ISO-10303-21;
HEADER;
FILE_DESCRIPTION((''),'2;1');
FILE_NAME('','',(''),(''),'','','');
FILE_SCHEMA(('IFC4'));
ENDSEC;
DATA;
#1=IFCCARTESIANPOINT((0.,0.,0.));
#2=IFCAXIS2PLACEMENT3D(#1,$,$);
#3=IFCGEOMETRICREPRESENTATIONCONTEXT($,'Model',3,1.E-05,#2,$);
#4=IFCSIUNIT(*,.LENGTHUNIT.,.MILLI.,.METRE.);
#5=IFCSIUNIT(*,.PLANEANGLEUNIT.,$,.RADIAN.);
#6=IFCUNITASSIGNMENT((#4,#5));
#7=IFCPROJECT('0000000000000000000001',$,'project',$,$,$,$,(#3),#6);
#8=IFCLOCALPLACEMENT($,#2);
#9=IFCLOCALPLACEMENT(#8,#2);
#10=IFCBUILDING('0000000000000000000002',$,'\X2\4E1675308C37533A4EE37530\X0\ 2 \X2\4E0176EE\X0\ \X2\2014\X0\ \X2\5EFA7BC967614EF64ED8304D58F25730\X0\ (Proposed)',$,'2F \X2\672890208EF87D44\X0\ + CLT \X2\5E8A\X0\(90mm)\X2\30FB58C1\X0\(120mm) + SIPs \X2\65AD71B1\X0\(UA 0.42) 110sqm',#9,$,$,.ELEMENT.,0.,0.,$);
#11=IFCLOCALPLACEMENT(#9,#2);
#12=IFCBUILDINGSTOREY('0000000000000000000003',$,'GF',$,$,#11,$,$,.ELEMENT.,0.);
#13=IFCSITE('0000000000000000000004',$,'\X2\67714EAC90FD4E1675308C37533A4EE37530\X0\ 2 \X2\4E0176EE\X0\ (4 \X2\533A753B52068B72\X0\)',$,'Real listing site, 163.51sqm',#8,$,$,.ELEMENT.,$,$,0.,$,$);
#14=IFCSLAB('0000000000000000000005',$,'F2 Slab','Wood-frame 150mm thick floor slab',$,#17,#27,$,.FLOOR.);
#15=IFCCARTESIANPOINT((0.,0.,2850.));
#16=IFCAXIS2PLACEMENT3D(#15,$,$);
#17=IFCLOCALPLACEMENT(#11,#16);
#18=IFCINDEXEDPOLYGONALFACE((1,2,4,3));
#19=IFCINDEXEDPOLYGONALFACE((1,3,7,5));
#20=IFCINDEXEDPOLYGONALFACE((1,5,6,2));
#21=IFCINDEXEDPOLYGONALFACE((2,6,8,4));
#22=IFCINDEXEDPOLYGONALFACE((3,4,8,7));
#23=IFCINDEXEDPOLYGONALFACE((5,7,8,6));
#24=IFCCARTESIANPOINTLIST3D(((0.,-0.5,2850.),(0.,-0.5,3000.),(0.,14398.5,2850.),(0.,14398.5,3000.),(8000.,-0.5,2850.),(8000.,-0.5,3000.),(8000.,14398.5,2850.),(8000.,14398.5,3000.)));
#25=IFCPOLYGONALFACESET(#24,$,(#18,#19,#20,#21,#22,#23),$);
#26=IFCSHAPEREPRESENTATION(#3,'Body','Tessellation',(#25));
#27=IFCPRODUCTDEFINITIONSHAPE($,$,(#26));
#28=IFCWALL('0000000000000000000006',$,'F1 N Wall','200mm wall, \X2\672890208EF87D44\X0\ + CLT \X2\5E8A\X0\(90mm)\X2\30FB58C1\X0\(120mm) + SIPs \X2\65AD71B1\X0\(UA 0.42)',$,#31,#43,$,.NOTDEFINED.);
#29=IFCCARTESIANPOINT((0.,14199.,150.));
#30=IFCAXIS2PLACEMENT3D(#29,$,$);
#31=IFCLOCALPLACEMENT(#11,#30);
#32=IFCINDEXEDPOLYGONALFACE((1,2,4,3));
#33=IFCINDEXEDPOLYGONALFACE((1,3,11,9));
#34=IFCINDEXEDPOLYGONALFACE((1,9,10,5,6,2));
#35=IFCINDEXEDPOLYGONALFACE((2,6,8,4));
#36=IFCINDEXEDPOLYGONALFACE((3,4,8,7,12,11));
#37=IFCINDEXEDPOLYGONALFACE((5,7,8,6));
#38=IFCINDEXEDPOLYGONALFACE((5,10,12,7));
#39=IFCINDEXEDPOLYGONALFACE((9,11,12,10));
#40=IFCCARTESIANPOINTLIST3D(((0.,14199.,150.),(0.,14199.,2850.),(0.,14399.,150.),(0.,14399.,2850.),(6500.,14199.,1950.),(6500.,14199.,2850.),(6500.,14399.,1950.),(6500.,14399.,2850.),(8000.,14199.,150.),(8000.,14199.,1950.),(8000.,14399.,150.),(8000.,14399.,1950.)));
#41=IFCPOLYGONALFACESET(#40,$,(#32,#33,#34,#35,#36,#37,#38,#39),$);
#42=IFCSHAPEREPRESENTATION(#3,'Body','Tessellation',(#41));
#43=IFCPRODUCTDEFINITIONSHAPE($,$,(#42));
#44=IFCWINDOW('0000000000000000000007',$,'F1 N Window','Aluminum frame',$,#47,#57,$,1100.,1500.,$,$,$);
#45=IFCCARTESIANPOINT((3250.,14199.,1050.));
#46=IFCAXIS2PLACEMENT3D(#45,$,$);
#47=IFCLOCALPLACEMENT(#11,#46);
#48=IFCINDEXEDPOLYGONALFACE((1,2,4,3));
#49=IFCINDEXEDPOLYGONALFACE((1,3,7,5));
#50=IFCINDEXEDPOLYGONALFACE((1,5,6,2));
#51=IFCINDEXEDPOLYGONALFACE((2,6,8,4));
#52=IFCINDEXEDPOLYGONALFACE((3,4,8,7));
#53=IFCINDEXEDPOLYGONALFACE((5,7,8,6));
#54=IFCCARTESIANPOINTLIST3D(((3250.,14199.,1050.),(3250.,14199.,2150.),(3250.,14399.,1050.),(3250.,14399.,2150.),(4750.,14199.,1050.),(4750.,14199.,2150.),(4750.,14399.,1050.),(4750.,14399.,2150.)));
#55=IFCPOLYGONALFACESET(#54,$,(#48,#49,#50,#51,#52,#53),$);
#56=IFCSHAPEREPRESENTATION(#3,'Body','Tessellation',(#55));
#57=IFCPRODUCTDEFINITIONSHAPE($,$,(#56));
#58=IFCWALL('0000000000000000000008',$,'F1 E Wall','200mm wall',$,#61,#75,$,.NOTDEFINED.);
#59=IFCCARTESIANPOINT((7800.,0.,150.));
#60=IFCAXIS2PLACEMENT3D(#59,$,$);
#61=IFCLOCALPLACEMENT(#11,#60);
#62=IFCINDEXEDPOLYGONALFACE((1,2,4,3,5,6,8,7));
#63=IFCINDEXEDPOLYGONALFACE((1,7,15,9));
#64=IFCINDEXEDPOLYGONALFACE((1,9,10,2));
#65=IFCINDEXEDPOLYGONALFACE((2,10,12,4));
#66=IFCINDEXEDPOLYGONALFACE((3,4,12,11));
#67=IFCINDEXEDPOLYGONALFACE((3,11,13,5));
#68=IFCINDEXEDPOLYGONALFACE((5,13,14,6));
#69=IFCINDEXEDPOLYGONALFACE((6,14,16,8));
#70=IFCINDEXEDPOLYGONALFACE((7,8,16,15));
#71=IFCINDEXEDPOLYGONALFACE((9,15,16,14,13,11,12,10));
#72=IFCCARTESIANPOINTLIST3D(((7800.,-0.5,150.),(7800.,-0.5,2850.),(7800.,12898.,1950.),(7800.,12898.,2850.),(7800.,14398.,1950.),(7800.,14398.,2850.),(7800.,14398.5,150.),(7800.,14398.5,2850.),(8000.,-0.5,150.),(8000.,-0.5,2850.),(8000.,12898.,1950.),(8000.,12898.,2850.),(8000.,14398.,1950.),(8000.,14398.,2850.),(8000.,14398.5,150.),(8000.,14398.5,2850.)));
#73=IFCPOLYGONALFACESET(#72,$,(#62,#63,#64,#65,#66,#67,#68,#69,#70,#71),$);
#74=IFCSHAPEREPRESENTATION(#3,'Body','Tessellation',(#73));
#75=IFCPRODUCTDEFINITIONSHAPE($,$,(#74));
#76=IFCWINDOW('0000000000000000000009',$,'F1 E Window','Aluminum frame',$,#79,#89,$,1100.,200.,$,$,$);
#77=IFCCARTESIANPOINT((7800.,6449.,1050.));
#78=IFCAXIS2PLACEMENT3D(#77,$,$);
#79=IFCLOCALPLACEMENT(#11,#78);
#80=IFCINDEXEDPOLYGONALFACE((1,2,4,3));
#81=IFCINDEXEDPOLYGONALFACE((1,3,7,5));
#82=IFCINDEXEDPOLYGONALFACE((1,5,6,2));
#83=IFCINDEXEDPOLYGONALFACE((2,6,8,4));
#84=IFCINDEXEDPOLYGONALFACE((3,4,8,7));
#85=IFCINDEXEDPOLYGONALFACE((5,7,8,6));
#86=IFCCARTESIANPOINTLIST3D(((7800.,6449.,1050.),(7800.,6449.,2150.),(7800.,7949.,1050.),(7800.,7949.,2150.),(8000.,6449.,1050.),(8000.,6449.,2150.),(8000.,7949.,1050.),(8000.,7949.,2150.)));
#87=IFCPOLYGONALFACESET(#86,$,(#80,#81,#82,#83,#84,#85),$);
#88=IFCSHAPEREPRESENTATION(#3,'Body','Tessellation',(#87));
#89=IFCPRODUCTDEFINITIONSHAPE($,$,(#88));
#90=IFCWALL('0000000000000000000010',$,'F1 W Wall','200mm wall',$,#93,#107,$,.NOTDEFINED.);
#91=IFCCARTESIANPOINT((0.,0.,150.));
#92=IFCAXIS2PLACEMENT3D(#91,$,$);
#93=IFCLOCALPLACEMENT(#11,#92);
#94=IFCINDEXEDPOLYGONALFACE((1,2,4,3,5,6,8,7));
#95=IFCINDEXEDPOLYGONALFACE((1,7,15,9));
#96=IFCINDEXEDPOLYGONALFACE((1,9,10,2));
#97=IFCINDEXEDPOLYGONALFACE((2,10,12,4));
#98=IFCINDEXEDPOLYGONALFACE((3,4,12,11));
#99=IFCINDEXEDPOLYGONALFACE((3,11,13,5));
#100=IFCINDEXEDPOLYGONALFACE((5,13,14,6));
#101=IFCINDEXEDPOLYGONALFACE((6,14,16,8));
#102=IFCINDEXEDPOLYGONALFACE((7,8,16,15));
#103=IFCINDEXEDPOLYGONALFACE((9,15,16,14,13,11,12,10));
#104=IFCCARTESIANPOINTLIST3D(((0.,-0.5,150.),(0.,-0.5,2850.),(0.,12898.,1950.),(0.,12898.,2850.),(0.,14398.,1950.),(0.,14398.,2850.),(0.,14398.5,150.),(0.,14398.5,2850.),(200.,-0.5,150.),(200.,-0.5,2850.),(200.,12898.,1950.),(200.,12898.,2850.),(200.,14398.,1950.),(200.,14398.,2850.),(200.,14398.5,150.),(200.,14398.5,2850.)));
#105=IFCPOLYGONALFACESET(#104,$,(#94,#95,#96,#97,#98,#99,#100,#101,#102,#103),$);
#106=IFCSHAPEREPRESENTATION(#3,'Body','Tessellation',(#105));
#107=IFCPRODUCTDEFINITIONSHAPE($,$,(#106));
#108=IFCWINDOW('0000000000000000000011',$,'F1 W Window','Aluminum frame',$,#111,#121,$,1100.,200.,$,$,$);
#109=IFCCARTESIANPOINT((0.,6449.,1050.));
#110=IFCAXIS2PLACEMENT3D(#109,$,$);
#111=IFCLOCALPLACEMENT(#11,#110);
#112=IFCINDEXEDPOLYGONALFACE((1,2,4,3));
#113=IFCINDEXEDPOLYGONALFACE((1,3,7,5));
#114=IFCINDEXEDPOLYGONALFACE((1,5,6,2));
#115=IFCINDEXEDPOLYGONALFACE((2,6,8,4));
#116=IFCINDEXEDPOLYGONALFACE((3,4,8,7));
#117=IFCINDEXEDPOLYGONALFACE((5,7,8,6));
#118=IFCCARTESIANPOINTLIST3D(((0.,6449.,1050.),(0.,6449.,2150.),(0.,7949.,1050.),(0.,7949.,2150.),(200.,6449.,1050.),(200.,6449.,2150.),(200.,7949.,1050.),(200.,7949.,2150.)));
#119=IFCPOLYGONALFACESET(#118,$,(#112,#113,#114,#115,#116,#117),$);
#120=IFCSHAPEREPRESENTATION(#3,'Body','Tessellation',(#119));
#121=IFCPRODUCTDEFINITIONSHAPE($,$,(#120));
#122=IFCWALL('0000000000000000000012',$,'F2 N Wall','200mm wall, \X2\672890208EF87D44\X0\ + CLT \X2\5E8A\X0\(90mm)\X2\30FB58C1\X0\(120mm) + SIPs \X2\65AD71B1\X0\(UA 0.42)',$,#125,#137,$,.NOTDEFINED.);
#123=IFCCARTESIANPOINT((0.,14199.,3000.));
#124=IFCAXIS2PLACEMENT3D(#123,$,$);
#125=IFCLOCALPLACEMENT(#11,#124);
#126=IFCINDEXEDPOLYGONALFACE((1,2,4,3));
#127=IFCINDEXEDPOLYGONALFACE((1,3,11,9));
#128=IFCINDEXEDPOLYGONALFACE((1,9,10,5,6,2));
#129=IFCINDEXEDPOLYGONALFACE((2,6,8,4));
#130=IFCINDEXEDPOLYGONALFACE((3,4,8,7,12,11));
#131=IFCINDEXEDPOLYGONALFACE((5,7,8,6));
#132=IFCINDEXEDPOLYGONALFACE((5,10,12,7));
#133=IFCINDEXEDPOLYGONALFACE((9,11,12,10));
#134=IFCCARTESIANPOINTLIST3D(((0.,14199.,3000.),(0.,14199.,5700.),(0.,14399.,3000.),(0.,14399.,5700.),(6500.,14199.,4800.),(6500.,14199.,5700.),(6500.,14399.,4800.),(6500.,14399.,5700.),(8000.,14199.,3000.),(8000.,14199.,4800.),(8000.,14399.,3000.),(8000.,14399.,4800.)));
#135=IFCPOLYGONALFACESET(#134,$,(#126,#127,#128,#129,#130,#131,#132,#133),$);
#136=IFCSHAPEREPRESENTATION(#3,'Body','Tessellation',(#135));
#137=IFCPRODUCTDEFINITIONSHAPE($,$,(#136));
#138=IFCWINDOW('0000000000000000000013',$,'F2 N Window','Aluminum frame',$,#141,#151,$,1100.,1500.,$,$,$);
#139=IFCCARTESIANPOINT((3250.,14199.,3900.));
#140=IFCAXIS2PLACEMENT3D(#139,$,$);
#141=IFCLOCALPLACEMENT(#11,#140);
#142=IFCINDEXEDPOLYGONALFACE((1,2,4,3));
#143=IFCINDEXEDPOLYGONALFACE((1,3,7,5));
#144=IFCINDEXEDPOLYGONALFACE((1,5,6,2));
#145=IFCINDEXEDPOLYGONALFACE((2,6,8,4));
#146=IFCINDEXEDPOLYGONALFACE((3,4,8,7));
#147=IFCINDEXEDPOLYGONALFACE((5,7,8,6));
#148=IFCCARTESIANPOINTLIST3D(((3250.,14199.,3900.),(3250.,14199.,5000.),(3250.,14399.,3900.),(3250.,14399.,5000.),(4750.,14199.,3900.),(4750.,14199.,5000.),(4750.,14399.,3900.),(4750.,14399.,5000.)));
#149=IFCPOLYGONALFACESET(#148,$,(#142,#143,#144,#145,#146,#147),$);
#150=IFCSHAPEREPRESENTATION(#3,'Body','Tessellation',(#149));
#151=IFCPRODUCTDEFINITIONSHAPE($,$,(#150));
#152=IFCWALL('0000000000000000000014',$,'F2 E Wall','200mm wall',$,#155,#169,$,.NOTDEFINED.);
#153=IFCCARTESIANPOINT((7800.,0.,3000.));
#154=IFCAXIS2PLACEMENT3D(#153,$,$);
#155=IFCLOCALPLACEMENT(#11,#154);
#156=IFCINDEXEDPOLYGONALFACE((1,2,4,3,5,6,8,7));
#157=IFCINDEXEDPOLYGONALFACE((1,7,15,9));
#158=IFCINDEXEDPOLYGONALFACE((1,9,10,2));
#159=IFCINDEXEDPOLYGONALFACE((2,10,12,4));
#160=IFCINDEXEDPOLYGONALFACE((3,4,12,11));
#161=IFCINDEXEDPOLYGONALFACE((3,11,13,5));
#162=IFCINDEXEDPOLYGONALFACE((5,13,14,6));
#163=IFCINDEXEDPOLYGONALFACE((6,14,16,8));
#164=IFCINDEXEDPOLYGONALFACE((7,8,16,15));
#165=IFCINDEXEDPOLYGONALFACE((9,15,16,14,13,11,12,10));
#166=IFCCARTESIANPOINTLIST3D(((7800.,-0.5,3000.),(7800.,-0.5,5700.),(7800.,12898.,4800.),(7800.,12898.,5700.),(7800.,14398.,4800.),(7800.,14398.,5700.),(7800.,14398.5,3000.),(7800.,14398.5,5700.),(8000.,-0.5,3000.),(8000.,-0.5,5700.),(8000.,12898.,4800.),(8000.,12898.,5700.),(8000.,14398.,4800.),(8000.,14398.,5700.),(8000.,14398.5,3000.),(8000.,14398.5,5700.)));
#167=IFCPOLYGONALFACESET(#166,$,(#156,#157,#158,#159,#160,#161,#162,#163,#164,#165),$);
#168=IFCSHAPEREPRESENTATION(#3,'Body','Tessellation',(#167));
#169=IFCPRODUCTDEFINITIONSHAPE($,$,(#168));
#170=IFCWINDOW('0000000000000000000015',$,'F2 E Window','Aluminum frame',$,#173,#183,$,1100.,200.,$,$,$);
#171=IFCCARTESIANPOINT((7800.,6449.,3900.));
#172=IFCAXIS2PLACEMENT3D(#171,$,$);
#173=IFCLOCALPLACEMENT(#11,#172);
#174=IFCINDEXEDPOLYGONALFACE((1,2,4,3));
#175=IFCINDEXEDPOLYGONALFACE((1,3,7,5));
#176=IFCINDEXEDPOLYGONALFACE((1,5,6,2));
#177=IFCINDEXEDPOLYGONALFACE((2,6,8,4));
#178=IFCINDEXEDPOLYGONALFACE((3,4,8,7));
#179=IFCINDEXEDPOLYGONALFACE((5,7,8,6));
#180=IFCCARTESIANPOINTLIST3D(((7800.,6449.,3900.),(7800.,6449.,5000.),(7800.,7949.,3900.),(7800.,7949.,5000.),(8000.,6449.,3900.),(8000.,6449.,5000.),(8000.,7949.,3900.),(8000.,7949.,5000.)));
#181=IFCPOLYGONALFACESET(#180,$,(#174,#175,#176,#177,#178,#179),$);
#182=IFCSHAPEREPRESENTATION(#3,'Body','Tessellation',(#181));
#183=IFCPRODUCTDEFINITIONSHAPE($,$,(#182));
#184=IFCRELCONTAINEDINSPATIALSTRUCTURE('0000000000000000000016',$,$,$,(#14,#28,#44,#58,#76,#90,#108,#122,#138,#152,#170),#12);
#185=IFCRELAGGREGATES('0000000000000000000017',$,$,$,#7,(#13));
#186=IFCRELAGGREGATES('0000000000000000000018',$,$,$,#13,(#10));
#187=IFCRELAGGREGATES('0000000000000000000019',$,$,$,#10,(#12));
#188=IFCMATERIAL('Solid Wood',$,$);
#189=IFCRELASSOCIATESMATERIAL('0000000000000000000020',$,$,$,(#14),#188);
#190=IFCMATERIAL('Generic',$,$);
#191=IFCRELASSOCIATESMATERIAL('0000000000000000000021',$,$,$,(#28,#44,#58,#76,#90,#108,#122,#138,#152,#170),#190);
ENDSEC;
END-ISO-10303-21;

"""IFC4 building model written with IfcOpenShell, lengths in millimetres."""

from ifc_helpers import new_model, si_unit, frame, frame_2d, origin, place, context, project, spatial, rectangle, extrude, material, element, fill, save


model = new_model("IFC4")

# Units and contexts
model_context = context("Model", 3, precision=1e-05, world=origin())
ifc_project = project(units=[si_unit("LENGTHUNIT", "METRE", prefix="MILLI"), si_unit("PLANEANGLEUNIT", "RADIAN")], contexts=[model_context])

# Site, building, storey
site_placement = place(None, origin())
site = spatial("IfcSite", under=ifc_project, at=site_placement, Name="東京都世田谷区代田 2 丁目 (4 区画分譲)", ObjectType="Real listing site, 163.51sqm", CompositionType="ELEMENT", RefElevation=0.0)
building_placement = place(site_placement, origin())
building = spatial("IfcBuilding", under=site, at=building_placement, Name="世田谷区代田 2 丁目 — 建築条件付き売地 (Proposed)", ObjectType="2F 木造軸組 + CLT 床(90mm)・壁(120mm) + SIPs 断熱(UA 0.42) 110sqm", CompositionType="ELEMENT", ElevationOfRefHeight=0.0, ElevationOfTerrain=0.0)
storey_placement = place(building_placement, origin())
storey = spatial("IfcBuildingStorey", under=building, at=storey_placement, Name="GF", CompositionType="ELEMENT", Elevation=0.0)

# Slab
ifc_material_1 = material(Name="Solid Wood")
slab_1_placement = place(storey_placement, frame((0.0, 0.0, 2850.0)))
element("IfcSlab", 1, at=slab_1_placement, inside=storey, material=ifc_material_1, Name="F2 Slab", Description="Wood-frame 150mm thick floor slab", PredefinedType="FLOOR", context=model_context, shape_type="SweptSolid", body=[
    extrude(rectangle(XDim=8000.0, YDim=14399.0, at=frame_2d((4000.0, 7199.0))), frame((0.0, 0.0, 2850.0)), (0.0, 0.0, 1.0), 150.0),
])

# Wall, opening, window
ifc_material_2 = material(Name="Generic")
wall_1_placement = place(storey_placement, frame((0.0, 14199.0, 150.0)))
wall_1 = element("IfcWall", 2, at=wall_1_placement, inside=storey, material=ifc_material_2, Name="F1 N Wall", Description="200mm wall, 木造軸組 + CLT 床(90mm)・壁(120mm) + SIPs 断熱(UA 0.42)", PredefinedType="NOTDEFINED", context=model_context, shape_type="SweptSolid", body=[
    extrude(rectangle(XDim=8000.0, YDim=200.0, at=frame_2d((4000.0, 100.0))), frame((0.0, 14199.0, 150.0)), (0.0, 0.0, 1.0), 2700.0),
])
opening_1_placement = place(storey_placement, frame((3250.0, 14199.0, 1050.0)))
opening_1 = element("IfcOpeningElement", 3, at=opening_1_placement, cuts=wall_1, PredefinedType="NOTDEFINED", context=model_context, shape_type="SweptSolid", body=[
    extrude(rectangle(XDim=1500.0, YDim=200.0, at=frame_2d((750.0, 100.0))), frame((3250.0, 14199.0, 1050.0)), (0.0, 0.0, 1.0), 1100.0),
])
window_1_placement = place(storey_placement, frame((3250.0, 14199.0, 1050.0)))
window_1 = element("IfcWindow", 4, at=window_1_placement, inside=storey, material=ifc_material_2, Name="F1 N Window", Description="Aluminum frame", OverallHeight=1100.0, OverallWidth=1500.0, context=model_context, shape_type="SweptSolid", body=[
    extrude(rectangle(XDim=1500.0, YDim=200.0, at=frame_2d((750.0, 100.0))), frame((3250.0, 14199.0, 1050.0)), (0.0, 0.0, 1.0), 1100.0),
])
fill(opening_1, window_1)

# Walls, openings, windows
wall_2_placement = place(storey_placement, frame((7800.0, 0.0, 150.0)))
wall_2 = element("IfcWall", 5, at=wall_2_placement, inside=storey, material=ifc_material_2, Name="F1 E Wall", Description="200mm wall", PredefinedType="NOTDEFINED", context=model_context, shape_type="SweptSolid", body=[
    extrude(rectangle(XDim=200.0, YDim=14399.0, at=frame_2d((100.0, 7199.0))), frame((7800.0, 0.0, 150.0)), (0.0, 0.0, 1.0), 2700.0),
])
opening_2_placement = place(storey_placement, frame((7800.0, 6449.0, 1050.0)))
opening_2 = element("IfcOpeningElement", 6, at=opening_2_placement, cuts=wall_2, PredefinedType="NOTDEFINED", context=model_context, shape_type="SweptSolid", body=[
    extrude(rectangle(XDim=200.0, YDim=1500.0, at=frame_2d((100.0, 750.0))), frame((7800.0, 6449.0, 1050.0)), (0.0, 0.0, 1.0), 1100.0),
])
window_2_placement = place(storey_placement, frame((7800.0, 6449.0, 1050.0)))
window_2 = element("IfcWindow", 7, at=window_2_placement, inside=storey, material=ifc_material_2, Name="F1 E Window", Description="Aluminum frame", OverallHeight=1100.0, OverallWidth=200.0, context=model_context, shape_type="SweptSolid", body=[
    extrude(rectangle(XDim=200.0, YDim=1500.0, at=frame_2d((100.0, 750.0))), frame((7800.0, 6449.0, 1050.0)), (0.0, 0.0, 1.0), 1100.0),
])
fill(opening_2, window_2)
wall_3_placement = place(storey_placement, frame((0.0, 0.0, 150.0)))
wall_3 = element("IfcWall", 8, at=wall_3_placement, inside=storey, material=ifc_material_2, Name="F1 W Wall", Description="200mm wall", PredefinedType="NOTDEFINED", context=model_context, shape_type="SweptSolid", body=[
    extrude(rectangle(XDim=200.0, YDim=14399.0, at=frame_2d((100.0, 7199.0))), frame((0.0, 0.0, 150.0)), (0.0, 0.0, 1.0), 2700.0),
])
opening_3_placement = place(storey_placement, frame((0.0, 6449.0, 1050.0)))
opening_3 = element("IfcOpeningElement", 9, at=opening_3_placement, cuts=wall_3, PredefinedType="NOTDEFINED", context=model_context, shape_type="SweptSolid", body=[
    extrude(rectangle(XDim=200.0, YDim=1500.0, at=frame_2d((100.0, 750.0))), frame((0.0, 6449.0, 1050.0)), (0.0, 0.0, 1.0), 1100.0),
])
window_3_placement = place(storey_placement, frame((0.0, 6449.0, 1050.0)))
window_3 = element("IfcWindow", 10, at=window_3_placement, inside=storey, material=ifc_material_2, Name="F1 W Window", Description="Aluminum frame", OverallHeight=1100.0, OverallWidth=200.0, context=model_context, shape_type="SweptSolid", body=[
    extrude(rectangle(XDim=200.0, YDim=1500.0, at=frame_2d((100.0, 750.0))), frame((0.0, 6449.0, 1050.0)), (0.0, 0.0, 1.0), 1100.0),
])
fill(opening_3, window_3)
wall_4_placement = place(storey_placement, frame((0.0, 14199.0, 3000.0)))
wall_4 = element("IfcWall", 11, at=wall_4_placement, inside=storey, material=ifc_material_2, Name="F2 N Wall", Description="200mm wall, 木造軸組 + CLT 床(90mm)・壁(120mm) + SIPs 断熱(UA 0.42)", PredefinedType="NOTDEFINED", context=model_context, shape_type="SweptSolid", body=[
    extrude(rectangle(XDim=8000.0, YDim=200.0, at=frame_2d((4000.0, 100.0))), frame((0.0, 14199.0, 3000.0)), (0.0, 0.0, 1.0), 2700.0),
])
opening_4_placement = place(storey_placement, frame((3250.0, 14199.0, 3900.0)))
opening_4 = element("IfcOpeningElement", 12, at=opening_4_placement, cuts=wall_4, PredefinedType="NOTDEFINED", context=model_context, shape_type="SweptSolid", body=[
    extrude(rectangle(XDim=1500.0, YDim=200.0, at=frame_2d((750.0, 100.0))), frame((3250.0, 14199.0, 3900.0)), (0.0, 0.0, 1.0), 1100.0),
])
window_4_placement = place(storey_placement, frame((3250.0, 14199.0, 3900.0)))
window_4 = element("IfcWindow", 13, at=window_4_placement, inside=storey, material=ifc_material_2, Name="F2 N Window", Description="Aluminum frame", OverallHeight=1100.0, OverallWidth=1500.0, context=model_context, shape_type="SweptSolid", body=[
    extrude(rectangle(XDim=1500.0, YDim=200.0, at=frame_2d((750.0, 100.0))), frame((3250.0, 14199.0, 3900.0)), (0.0, 0.0, 1.0), 1100.0),
])
fill(opening_4, window_4)
wall_5_placement = place(storey_placement, frame((7800.0, 0.0, 3000.0)))
wall_5 = element("IfcWall", 14, at=wall_5_placement, inside=storey, material=ifc_material_2, Name="F2 E Wall", Description="200mm wall", PredefinedType="NOTDEFINED", context=model_context, shape_type="SweptSolid", body=[
    extrude(rectangle(XDim=200.0, YDim=14399.0, at=frame_2d((100.0, 7199.0))), frame((7800.0, 0.0, 3000.0)), (0.0, 0.0, 1.0), 2700.0),
])
opening_5_placement = place(storey_placement, frame((7800.0, 6449.0, 3900.0)))
opening_5 = element("IfcOpeningElement", 15, at=opening_5_placement, cuts=wall_5, PredefinedType="NOTDEFINED", context=model_context, shape_type="SweptSolid", body=[
    extrude(rectangle(XDim=200.0, YDim=1500.0, at=frame_2d((100.0, 750.0))), frame((7800.0, 6449.0, 3900.0)), (0.0, 0.0, 1.0), 1100.0),
])
window_5_placement = place(storey_placement, frame((7800.0, 6449.0, 3900.0)))
window_5 = element("IfcWindow", 16, at=window_5_placement, inside=storey, material=ifc_material_2, Name="F2 E Window", Description="Aluminum frame", OverallHeight=1100.0, OverallWidth=200.0, context=model_context, shape_type="SweptSolid", body=[
    extrude(rectangle(XDim=200.0, YDim=1500.0, at=frame_2d((100.0, 750.0))), frame((7800.0, 6449.0, 3900.0)), (0.0, 0.0, 1.0), 1100.0),
])
fill(opening_5, window_5)

save(model, "model.ifc")
